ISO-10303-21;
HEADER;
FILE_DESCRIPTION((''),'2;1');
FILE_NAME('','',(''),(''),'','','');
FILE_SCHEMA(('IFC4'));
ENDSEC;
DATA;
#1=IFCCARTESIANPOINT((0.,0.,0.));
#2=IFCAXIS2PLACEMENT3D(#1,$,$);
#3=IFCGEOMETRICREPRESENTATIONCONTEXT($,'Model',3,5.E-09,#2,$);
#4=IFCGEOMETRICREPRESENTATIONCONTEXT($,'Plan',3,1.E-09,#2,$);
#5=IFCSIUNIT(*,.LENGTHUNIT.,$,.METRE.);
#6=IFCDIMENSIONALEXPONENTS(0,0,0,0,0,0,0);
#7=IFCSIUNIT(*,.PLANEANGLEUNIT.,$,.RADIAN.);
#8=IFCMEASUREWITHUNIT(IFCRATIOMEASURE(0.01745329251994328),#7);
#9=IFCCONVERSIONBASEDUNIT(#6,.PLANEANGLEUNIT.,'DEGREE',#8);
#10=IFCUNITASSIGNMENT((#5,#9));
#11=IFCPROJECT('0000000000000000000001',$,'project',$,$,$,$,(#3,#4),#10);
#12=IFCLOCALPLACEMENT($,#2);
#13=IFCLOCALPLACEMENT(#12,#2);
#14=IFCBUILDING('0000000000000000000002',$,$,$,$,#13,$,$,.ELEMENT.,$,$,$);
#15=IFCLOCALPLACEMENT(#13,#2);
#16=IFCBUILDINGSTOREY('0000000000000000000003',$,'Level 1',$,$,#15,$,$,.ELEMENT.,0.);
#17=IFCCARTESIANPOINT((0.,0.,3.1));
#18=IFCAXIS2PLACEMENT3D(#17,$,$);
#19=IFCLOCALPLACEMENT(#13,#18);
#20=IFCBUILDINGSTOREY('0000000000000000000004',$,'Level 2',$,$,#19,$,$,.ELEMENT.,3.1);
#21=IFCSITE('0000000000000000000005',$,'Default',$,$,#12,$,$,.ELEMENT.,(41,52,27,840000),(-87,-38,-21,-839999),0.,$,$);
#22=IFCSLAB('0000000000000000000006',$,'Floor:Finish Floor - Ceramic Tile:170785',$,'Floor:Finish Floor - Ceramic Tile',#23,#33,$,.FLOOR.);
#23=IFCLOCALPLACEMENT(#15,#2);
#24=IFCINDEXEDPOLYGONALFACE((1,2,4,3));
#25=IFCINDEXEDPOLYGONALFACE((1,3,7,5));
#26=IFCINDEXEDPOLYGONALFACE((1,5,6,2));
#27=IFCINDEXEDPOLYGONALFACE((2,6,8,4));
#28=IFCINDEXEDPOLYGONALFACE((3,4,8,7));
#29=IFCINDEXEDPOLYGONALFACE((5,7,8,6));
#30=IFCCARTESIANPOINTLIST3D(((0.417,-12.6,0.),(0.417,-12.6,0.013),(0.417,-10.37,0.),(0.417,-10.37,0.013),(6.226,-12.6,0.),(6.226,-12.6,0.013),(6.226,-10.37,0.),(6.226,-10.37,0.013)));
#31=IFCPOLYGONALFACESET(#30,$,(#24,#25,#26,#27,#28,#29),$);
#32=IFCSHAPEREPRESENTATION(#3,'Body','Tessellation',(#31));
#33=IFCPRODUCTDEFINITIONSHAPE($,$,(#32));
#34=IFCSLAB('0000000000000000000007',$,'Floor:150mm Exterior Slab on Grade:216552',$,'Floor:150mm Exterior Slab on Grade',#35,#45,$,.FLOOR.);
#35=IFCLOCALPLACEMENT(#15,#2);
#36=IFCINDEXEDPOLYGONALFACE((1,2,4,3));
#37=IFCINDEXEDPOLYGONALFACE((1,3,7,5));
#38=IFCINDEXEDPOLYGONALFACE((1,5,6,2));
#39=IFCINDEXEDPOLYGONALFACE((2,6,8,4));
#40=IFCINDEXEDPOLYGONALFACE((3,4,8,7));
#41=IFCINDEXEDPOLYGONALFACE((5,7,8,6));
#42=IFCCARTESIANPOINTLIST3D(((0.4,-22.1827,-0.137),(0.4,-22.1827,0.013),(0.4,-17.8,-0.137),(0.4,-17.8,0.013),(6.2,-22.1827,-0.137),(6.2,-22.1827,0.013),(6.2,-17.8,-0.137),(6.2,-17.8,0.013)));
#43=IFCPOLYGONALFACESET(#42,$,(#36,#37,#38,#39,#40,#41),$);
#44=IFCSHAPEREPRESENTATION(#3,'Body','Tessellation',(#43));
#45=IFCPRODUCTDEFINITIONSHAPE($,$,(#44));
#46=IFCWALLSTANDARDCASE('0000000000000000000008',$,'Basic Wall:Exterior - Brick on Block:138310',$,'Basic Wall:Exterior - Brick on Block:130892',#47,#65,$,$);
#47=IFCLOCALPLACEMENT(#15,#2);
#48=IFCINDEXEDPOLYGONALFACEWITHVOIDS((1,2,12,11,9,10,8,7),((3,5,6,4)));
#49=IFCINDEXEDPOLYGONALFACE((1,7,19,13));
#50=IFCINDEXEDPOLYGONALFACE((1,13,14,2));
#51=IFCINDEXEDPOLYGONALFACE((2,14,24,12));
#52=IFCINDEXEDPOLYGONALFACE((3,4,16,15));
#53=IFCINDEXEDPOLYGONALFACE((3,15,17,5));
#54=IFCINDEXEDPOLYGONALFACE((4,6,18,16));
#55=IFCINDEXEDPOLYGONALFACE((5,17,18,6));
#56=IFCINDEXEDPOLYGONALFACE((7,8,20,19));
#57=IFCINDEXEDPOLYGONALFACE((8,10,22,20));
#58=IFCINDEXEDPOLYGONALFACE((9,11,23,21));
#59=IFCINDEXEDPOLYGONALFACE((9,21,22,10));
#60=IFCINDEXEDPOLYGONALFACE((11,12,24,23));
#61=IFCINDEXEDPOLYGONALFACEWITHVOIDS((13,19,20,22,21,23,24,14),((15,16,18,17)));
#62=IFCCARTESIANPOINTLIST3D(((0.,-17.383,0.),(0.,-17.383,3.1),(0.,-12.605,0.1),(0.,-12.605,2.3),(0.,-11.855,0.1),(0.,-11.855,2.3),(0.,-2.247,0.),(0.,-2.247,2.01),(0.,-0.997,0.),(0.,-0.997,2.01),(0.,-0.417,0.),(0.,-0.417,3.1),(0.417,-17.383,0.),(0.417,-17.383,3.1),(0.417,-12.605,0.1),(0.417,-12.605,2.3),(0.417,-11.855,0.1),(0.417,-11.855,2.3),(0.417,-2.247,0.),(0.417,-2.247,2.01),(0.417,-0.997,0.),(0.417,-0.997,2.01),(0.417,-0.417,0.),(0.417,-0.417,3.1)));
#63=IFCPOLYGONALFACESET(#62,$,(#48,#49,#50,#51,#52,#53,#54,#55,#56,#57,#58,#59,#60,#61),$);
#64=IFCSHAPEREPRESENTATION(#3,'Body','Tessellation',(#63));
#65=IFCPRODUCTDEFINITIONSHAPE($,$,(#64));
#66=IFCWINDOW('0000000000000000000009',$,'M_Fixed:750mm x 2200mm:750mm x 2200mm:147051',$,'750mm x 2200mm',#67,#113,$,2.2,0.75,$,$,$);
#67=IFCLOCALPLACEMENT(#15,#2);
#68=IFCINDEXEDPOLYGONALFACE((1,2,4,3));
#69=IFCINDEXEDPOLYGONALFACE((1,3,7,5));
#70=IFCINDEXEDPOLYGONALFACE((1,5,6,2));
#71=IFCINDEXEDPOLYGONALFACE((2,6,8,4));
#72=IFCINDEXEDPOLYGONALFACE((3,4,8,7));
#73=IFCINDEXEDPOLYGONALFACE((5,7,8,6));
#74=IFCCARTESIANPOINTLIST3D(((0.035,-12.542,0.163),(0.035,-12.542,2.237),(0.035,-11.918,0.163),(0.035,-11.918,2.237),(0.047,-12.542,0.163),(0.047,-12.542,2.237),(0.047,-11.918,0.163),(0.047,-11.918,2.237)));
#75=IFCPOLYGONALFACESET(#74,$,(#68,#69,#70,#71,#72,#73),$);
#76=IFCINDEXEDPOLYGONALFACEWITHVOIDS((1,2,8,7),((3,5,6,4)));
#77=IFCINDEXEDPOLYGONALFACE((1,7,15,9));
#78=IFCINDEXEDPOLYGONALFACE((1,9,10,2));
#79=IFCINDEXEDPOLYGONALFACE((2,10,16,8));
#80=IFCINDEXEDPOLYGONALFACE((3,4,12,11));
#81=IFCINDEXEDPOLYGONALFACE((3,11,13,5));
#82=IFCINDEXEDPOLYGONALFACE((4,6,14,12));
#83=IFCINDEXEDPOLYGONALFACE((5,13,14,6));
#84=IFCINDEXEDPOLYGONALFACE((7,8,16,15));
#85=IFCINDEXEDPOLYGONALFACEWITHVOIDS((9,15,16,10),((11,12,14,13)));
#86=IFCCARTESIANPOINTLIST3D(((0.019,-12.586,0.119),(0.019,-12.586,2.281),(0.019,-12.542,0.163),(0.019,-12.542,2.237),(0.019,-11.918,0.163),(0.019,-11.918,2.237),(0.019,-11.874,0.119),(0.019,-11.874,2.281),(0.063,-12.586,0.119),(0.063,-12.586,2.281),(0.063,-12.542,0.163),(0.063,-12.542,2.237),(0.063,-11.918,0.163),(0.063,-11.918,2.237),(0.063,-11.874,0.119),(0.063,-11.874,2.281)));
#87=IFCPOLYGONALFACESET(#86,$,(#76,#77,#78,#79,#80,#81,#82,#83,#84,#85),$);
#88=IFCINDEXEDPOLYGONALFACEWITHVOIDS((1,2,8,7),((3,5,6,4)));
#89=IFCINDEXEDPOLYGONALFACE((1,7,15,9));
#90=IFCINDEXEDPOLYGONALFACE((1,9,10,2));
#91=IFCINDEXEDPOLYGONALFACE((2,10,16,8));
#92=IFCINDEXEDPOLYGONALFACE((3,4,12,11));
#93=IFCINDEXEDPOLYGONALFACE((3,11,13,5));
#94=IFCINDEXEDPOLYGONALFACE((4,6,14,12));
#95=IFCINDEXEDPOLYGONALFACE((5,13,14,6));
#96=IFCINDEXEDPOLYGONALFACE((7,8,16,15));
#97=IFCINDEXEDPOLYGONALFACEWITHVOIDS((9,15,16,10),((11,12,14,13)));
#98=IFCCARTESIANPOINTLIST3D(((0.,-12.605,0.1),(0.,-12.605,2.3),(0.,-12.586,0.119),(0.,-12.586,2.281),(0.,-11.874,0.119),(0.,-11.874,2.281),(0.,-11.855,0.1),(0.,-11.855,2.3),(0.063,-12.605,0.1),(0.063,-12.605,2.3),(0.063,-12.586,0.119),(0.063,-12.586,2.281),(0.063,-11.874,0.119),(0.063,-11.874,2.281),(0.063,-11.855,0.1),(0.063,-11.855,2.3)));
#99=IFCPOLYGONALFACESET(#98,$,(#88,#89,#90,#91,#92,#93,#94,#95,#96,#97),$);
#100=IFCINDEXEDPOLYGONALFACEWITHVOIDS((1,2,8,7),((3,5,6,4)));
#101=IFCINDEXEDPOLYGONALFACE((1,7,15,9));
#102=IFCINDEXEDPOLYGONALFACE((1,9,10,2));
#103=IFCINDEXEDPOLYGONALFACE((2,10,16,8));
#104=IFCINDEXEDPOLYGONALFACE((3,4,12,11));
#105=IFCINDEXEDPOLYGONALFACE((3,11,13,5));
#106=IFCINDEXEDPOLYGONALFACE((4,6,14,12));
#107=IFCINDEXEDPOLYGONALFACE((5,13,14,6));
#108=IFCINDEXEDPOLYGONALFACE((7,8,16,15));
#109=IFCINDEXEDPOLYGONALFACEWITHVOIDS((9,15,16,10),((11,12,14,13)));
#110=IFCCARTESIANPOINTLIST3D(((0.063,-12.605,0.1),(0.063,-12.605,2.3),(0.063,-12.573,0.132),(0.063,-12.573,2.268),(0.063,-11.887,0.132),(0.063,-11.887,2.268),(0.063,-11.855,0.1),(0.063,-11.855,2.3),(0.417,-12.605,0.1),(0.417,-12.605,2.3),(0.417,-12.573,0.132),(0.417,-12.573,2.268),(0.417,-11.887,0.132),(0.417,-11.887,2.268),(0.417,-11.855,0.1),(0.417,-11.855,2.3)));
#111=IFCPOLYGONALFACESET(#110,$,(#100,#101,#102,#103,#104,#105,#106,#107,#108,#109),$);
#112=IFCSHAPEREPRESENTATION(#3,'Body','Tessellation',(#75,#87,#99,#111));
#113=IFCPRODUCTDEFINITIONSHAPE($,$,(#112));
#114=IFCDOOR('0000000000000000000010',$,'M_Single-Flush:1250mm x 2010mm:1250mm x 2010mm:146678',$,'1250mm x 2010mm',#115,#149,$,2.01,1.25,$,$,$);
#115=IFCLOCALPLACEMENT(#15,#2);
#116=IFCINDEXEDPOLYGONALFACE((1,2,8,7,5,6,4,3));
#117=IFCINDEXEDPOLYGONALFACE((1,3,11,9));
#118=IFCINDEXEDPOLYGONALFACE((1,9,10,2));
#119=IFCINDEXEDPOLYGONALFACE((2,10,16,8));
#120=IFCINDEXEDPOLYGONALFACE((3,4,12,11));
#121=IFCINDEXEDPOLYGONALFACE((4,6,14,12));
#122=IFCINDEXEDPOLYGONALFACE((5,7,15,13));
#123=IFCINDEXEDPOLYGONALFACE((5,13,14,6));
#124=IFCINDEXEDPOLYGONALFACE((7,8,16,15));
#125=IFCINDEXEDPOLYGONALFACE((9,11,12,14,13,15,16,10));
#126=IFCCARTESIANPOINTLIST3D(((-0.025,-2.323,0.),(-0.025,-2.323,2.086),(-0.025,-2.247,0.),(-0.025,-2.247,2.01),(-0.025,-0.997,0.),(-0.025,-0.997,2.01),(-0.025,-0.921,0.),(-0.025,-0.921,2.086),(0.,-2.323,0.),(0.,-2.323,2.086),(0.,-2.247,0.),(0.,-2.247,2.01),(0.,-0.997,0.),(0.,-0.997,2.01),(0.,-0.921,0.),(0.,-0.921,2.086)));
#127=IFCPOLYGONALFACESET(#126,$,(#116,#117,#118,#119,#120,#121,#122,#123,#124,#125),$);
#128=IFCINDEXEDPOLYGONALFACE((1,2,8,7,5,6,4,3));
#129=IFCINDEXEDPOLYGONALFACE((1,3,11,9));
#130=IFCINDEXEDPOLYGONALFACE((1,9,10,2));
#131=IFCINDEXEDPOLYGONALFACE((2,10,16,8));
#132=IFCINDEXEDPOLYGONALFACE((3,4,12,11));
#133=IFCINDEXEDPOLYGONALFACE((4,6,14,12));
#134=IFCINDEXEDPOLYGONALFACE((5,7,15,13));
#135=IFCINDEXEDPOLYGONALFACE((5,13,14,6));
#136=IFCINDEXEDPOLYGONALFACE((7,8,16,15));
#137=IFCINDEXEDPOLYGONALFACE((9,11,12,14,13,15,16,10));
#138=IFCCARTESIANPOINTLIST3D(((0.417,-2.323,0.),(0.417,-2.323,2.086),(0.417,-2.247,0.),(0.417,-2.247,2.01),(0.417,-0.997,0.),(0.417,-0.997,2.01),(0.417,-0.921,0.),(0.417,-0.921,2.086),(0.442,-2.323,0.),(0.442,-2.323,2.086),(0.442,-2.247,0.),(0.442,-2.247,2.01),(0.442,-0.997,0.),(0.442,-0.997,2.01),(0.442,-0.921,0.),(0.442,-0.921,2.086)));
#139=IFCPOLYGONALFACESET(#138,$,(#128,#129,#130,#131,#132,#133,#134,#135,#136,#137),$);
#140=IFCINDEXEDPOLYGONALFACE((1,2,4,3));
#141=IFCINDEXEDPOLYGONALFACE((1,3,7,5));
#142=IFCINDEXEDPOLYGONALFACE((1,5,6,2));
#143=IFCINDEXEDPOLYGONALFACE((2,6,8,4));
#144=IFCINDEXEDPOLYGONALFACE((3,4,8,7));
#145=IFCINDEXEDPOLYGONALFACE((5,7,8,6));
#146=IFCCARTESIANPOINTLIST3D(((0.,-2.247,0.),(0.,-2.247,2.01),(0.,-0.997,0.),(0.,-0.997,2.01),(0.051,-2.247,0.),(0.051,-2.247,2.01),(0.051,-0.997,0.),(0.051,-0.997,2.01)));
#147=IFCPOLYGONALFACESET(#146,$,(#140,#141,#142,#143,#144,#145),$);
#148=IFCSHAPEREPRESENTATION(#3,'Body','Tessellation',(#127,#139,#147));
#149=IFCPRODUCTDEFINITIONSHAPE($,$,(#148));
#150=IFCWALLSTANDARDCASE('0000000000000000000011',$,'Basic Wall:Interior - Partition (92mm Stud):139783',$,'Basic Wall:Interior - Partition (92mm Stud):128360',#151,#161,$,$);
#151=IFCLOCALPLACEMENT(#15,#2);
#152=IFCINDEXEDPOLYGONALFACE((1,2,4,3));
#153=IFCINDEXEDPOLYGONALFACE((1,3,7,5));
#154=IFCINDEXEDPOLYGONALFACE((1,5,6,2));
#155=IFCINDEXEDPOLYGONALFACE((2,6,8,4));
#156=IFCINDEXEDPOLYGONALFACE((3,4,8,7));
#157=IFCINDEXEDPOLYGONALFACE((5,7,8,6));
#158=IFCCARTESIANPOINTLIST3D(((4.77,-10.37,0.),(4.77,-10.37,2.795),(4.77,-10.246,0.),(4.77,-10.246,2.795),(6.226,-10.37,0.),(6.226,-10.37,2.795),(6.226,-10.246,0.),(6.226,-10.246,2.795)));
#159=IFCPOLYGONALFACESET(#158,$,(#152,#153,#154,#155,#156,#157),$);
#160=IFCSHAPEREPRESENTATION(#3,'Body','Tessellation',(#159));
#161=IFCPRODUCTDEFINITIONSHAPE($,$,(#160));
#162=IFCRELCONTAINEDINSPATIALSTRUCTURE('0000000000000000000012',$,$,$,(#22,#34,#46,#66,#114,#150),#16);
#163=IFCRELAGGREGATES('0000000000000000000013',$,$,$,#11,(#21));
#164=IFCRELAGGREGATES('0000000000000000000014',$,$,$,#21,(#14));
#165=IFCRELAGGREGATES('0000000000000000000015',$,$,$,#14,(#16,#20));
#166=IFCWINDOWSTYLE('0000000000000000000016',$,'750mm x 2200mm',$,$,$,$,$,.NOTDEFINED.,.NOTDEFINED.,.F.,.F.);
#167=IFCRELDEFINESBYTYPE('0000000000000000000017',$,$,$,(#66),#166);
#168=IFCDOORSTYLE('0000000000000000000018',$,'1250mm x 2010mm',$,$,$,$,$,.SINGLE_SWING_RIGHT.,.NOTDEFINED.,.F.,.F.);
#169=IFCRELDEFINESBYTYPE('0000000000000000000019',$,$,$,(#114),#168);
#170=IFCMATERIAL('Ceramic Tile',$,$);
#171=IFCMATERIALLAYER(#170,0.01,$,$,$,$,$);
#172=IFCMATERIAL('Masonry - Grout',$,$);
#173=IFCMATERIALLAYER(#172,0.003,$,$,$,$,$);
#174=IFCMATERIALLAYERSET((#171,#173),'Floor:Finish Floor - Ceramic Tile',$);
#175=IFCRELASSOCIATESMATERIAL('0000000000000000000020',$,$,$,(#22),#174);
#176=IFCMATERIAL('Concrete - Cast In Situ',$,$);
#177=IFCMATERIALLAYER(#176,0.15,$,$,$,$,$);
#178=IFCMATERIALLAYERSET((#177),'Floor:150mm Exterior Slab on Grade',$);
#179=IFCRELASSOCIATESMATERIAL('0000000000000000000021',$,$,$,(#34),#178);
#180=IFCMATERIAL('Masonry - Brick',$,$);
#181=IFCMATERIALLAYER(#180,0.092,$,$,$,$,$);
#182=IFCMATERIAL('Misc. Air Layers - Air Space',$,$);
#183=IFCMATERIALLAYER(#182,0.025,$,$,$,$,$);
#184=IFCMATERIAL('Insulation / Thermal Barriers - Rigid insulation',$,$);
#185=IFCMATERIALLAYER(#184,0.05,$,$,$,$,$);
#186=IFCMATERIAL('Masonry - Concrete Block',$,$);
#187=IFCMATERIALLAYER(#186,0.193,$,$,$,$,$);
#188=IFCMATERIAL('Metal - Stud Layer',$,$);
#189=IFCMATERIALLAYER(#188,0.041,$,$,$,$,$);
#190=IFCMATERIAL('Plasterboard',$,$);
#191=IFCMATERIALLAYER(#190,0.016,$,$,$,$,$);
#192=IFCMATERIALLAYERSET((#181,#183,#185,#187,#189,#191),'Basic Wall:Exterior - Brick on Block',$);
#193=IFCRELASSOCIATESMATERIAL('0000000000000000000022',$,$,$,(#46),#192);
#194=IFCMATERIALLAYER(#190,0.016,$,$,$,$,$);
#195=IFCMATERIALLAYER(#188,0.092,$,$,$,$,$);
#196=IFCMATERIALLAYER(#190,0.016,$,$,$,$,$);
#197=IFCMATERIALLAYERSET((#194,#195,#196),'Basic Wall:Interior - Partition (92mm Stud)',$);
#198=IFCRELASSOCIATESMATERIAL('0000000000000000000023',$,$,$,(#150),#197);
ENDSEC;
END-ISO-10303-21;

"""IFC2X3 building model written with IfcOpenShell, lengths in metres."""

from ifc_helpers import new_model, entity, si_unit, converted_unit, frame, frame_2d, origin, origin_2d_with_axis, place, context, project, spatial, polyline, rectangle, outline, extrude, source, transform, mapped, material, layer, layer_set, layer_usage, type_object, type_shapes, element, fill, save


model = new_model("IFC2X3")

# Units and contexts
model_context = context("Model", 3, precision=5e-09, world=origin())
plan_context = context("Plan", 3, precision=1e-09, world=origin())
ifc_project = project(units=[si_unit("LENGTHUNIT", "METRE"), converted_unit("PLANEANGLEUNIT", "DEGREE", entity("IfcRatioMeasure", 0.01745329251994328), si_unit("PLANEANGLEUNIT", "RADIAN"), dimensions=[0, 0, 0, 0, 0, 0, 0])], contexts=[model_context, plan_context])

# Site, building, storey
site_placement = place(None, origin())
site = spatial("IfcSite", under=ifc_project, at=site_placement, Name="Default", CompositionType="ELEMENT", RefLatitude=(41, 52, 27, 840000), RefLongitude=(-87, -38, -21, -839999), RefElevation=0.0)
building_placement = place(site_placement, origin())
building = spatial("IfcBuilding", under=site, at=building_placement, CompositionType="ELEMENT")
storey_1_placement = place(building_placement, origin())
storey_1 = spatial("IfcBuildingStorey", under=building, at=storey_1_placement, Name="Level 1", CompositionType="ELEMENT", Elevation=0.0)

# Slabs
ifc_material_1 = material(Name="Ceramic Tile")
ifc_layer_1 = layer(ifc_material_1, 0.01)
ifc_material_2 = material(Name="Masonry - Grout")
ifc_layer_2 = layer(ifc_material_2, 0.003)
ifc_layer_set_1 = layer_set([ifc_layer_1, ifc_layer_2], Name="Floor:Finish Floor - Ceramic Tile")
ifc_layer_usage_1 = layer_usage(ifc_layer_set_1, "AXIS3", "POSITIVE", 0.0)
slab_1_placement = place(storey_1_placement, frame((0.417, -12.6, 0.0)))
element("IfcSlab", 1, at=slab_1_placement, inside=storey_1, material=ifc_layer_usage_1, Name="Floor:Finish Floor - Ceramic Tile:170785", ObjectType="Floor:Finish Floor - Ceramic Tile", PredefinedType="FLOOR", context=model_context, shape_type="SweptSolid", body=[
    extrude(rectangle(XDim=5.809, YDim=2.23, at=frame_2d((0.0, 0.0), x_axis=(-1.0, 0.0))), frame((2.9045, 1.115, 0.013), z_axis=(0.0, 0.0, -1.0), x_axis=(-1.0, 0.0, 0.0)), (0.0, 0.0, 1.0), 0.013),
])
ifc_material_3 = material(Name="Concrete - Cast In Situ")
ifc_layer_3 = layer(ifc_material_3, 0.15)
ifc_layer_set_2 = layer_set([ifc_layer_3], Name="Floor:150mm Exterior Slab on Grade")
ifc_layer_usage_2 = layer_usage(ifc_layer_set_2, "AXIS3", "POSITIVE", 0.0)
slab_2_placement = place(storey_1_placement, frame((0.4, -22.1827, -0.137)))
element("IfcSlab", 2, at=slab_2_placement, inside=storey_1, material=ifc_layer_usage_2, Name="Floor:150mm Exterior Slab on Grade:216552", ObjectType="Floor:150mm Exterior Slab on Grade", PredefinedType="FLOOR", context=model_context, shape_type="SweptSolid", body=[
    extrude(rectangle(XDim=5.8, YDim=4.3827, at=origin_2d_with_axis()), frame((2.9, 2.1914, 0.15), z_axis=(0.0, 0.0, -1.0), x_axis=(-1.0, 0.0, 0.0)), (0.0, 0.0, 1.0), 0.15),
])

# Wall, openings, window, door
ifc_material_4 = material(Name="Masonry - Brick")
ifc_layer_4 = layer(ifc_material_4, 0.092)
ifc_material_5 = material(Name="Misc. Air Layers - Air Space")
ifc_layer_5 = layer(ifc_material_5, 0.025)
ifc_material_6 = material(Name="Insulation / Thermal Barriers - Rigid insulation")
ifc_layer_6 = layer(ifc_material_6, 0.05)
ifc_material_7 = material(Name="Masonry - Concrete Block")
ifc_layer_7 = layer(ifc_material_7, 0.193)
ifc_material_8 = material(Name="Metal - Stud Layer")
ifc_layer_8 = layer(ifc_material_8, 0.041)
ifc_material_9 = material(Name="Plasterboard")
ifc_layer_9 = layer(ifc_material_9, 0.016)
ifc_layer_set_3 = layer_set([ifc_layer_4, ifc_layer_5, ifc_layer_6, ifc_layer_7, ifc_layer_8, ifc_layer_9], Name="Basic Wall:Exterior - Brick on Block")
ifc_layer_usage_3 = layer_usage(ifc_layer_set_3, "AXIS2", "NEGATIVE", 0.2085)
wall_1_placement = place(storey_1_placement, frame((0.2085, -17.383, 0.0), z_axis=(0.0, 0.0, 1.0), x_axis=(0.0, 1.0, 0.0)))
wall_1 = element("IfcWallStandardCase", 3, at=wall_1_placement, inside=storey_1, material=ifc_layer_usage_3, Name="Basic Wall:Exterior - Brick on Block:138310", ObjectType="Basic Wall:Exterior - Brick on Block:130892", context=model_context, shape_type="SweptSolid", body=[
    extrude(rectangle(XDim=16.966, YDim=0.417, at=frame_2d((8.483, 0.0), x_axis=(-1.0, 0.0))), origin(), (0.0, 0.0, 1.0), 3.1),
])
opening_1_placement = place(wall_1_placement, frame((15.136, -0.2085, 0.0)))
opening_1 = element("IfcOpeningElement", 4, at=opening_1_placement, cuts=wall_1, ObjectType="Opening", context=model_context, shape_type="SweptSolid", body=[
    extrude(rectangle(XDim=1.25, YDim=2.01, at=frame_2d((1.005, 0.625), x_axis=(0.0, 1.0))), frame((0.0, 0.0, 0.0), z_axis=(0.0, 1.0, 0.0), x_axis=(0.0, 0.0, 1.0)), (0.0, 0.0, 1.0), 0.417),
])
opening_2_placement = place(wall_1_placement, frame((4.778, -0.2085, 0.1)))
opening_2 = element("IfcOpeningElement", 5, at=opening_2_placement, cuts=wall_1, ObjectType="Opening", context=model_context, shape_type="SweptSolid", body=[
    extrude(rectangle(XDim=2.2, YDim=0.75, at=frame_2d((1.1, 0.375), x_axis=(1.0, 0.0))), frame((0.0, 0.0, 0.0), z_axis=(0.0, 1.0, 0.0), x_axis=(0.0, 0.0, 1.0)), (0.0, 0.0, 1.0), 0.417),
])
window_style_1 = type_object("IfcWindowStyle", Name="750mm x 2200mm", ConstructionType="NOTDEFINED", OperationType="NOTDEFINED", ParameterTakesPrecedence=False, Sizeable=False)
shared_shape_1 = source(origin(), model_context, "Body", "SweptSolid", [
    extrude(rectangle(XDim=0.012, YDim=0.624, at=origin_2d_with_axis()), frame((0.375, 0.376, 0.063), z_axis=(0.0, 0.0, 1.0), x_axis=(0.0, -1.0, 0.0)), (0.0, 0.0, 1.0), 2.074),
    extrude(outline(polyline([(-0.356, -1.081), (0.356, -1.081), (0.356, 1.081), (-0.356, 1.081), (-0.356, -1.081)]), holes=[polyline([(-0.312, -1.037), (-0.312, 1.037), (0.312, 1.037), (0.312, -1.037), (-0.312, -1.037)])]), frame((0.375, 0.354, 1.1), z_axis=(0.0, 1.0, 0.0), x_axis=(1.0, 0.0, 0.0)), (0.0, 0.0, 1.0), 0.044),
    extrude(outline(polyline([(-0.375, -1.1), (0.375, -1.1), (0.375, 1.1), (-0.375, 1.1), (-0.375, -1.1)]), holes=[polyline([(-0.356, -1.081), (-0.356, 1.081), (0.356, 1.081), (0.356, -1.081), (-0.356, -1.081)])]), frame((0.375, 0.354, 1.1), z_axis=(0.0, 1.0, 0.0), x_axis=(1.0, 0.0, 0.0)), (0.0, 0.0, 1.0), 0.063),
    extrude(outline(polyline([(-0.375, -1.1), (0.375, -1.1), (0.375, 1.1), (-0.375, 1.1), (-0.375, -1.1)]), holes=[polyline([(-0.343, -1.068), (-0.343, 1.068), (0.343, 1.068), (0.343, -1.068), (-0.343, -1.068)])]), frame((0.375, 0.0, 1.1), z_axis=(0.0, 1.0, 0.0), x_axis=(1.0, 0.0, 0.0)), (0.0, 0.0, 1.0), 0.354),
])
type_shapes(window_style_1, [shared_shape_1])
window_1_placement = place(opening_2_placement, origin())
window_1 = element("IfcWindow", 6, at=window_1_placement, inside=storey_1, type_object=window_style_1, Name="M_Fixed:750mm x 2200mm:750mm x 2200mm:147051", ObjectType="750mm x 2200mm", OverallHeight=2.2, OverallWidth=0.75, context=model_context, shape_type="MappedRepresentation", body=[
    mapped(shared_shape_1, transform((0.0, 0.0, 0.0), scale=1.0)),
])
fill(opening_2, window_1)
door_style_1 = type_object("IfcDoorStyle", Name="1250mm x 2010mm", ConstructionType="NOTDEFINED", OperationType="SINGLE_SWING_RIGHT", ParameterTakesPrecedence=False, Sizeable=False)
shared_shape_2 = source(origin(), model_context, "Body", "SweptSolid", [
    extrude(outline(polyline([(-0.701, -1.062), (0.701, -1.062), (0.701, 1.024), (0.625, 1.024), (0.625, -0.986), (-0.625, -0.986), (-0.625, 1.024), (-0.701, 1.024), (-0.701, -1.062)])), frame((0.625, 0.417, 1.024), z_axis=(0.0, 1.0, 0.0), x_axis=(1.0, 0.0, 0.0)), (0.0, 0.0, 1.0), 0.025),
    extrude(outline(polyline([(-1.062, -0.701), (1.024, -0.701), (1.024, -0.625), (-0.986, -0.625), (-0.986, 0.625), (1.024, 0.625), (1.024, 0.701), (-1.062, 0.701), (-1.062, -0.701)])), frame((0.625, -0.025, 1.024), z_axis=(0.0, 1.0, 0.0), x_axis=(0.0, 0.0, -1.0)), (0.0, 0.0, 1.0), 0.025),
    extrude(rectangle(XDim=0.051, YDim=1.25, at=origin_2d_with_axis()), frame((0.625, 0.3915, 0.0), z_axis=(0.0, 0.0, 1.0), x_axis=(0.0, 1.0, 0.0)), (0.0, 0.0, 1.0), 2.01),
])
type_shapes(door_style_1, [shared_shape_2])
door_1_placement = place(opening_1_placement, origin())
door_1 = element("IfcDoor", 7, at=door_1_placement, inside=storey_1, type_object=door_style_1, Name="M_Single-Flush:1250mm x 2010mm:1250mm x 2010mm:146678", ObjectType="1250mm x 2010mm", OverallHeight=2.01, OverallWidth=1.25, context=model_context, shape_type="MappedRepresentation", body=[
    mapped(shared_shape_2, transform((0.0, 0.0, 0.0), scale=1.0)),
])
fill(opening_1, door_1)

# Wall
ifc_layer_10 = layer(ifc_material_9, 0.016)
ifc_layer_11 = layer(ifc_material_8, 0.092)
ifc_layer_12 = layer(ifc_material_9, 0.016)
ifc_layer_set_4 = layer_set([ifc_layer_10, ifc_layer_11, ifc_layer_12], Name="Basic Wall:Interior - Partition (92mm Stud)")
ifc_layer_usage_4 = layer_usage(ifc_layer_set_4, "AXIS2", "NEGATIVE", 0.062)
wall_2_placement = place(storey_1_placement, frame((4.77, -10.308, 0.0)))
element("IfcWallStandardCase", 8, at=wall_2_placement, inside=storey_1, material=ifc_layer_usage_4, Name="Basic Wall:Interior - Partition (92mm Stud):139783", ObjectType="Basic Wall:Interior - Partition (92mm Stud):128360", context=model_context, shape_type="SweptSolid", body=[
    extrude(rectangle(XDim=1.456, YDim=0.124, at=frame_2d((0.728, 0.0), x_axis=(-1.0, 0.0))), origin(), (0.0, 0.0, 1.0), 2.795),
])

# Shared definitions
storey_2_placement = place(building_placement, frame((0.0, 0.0, 3.1)))
storey_2 = spatial("IfcBuildingStorey", under=building, at=storey_2_placement, Name="Level 2", CompositionType="ELEMENT", Elevation=3.1)

save(model, "model.ifc")
